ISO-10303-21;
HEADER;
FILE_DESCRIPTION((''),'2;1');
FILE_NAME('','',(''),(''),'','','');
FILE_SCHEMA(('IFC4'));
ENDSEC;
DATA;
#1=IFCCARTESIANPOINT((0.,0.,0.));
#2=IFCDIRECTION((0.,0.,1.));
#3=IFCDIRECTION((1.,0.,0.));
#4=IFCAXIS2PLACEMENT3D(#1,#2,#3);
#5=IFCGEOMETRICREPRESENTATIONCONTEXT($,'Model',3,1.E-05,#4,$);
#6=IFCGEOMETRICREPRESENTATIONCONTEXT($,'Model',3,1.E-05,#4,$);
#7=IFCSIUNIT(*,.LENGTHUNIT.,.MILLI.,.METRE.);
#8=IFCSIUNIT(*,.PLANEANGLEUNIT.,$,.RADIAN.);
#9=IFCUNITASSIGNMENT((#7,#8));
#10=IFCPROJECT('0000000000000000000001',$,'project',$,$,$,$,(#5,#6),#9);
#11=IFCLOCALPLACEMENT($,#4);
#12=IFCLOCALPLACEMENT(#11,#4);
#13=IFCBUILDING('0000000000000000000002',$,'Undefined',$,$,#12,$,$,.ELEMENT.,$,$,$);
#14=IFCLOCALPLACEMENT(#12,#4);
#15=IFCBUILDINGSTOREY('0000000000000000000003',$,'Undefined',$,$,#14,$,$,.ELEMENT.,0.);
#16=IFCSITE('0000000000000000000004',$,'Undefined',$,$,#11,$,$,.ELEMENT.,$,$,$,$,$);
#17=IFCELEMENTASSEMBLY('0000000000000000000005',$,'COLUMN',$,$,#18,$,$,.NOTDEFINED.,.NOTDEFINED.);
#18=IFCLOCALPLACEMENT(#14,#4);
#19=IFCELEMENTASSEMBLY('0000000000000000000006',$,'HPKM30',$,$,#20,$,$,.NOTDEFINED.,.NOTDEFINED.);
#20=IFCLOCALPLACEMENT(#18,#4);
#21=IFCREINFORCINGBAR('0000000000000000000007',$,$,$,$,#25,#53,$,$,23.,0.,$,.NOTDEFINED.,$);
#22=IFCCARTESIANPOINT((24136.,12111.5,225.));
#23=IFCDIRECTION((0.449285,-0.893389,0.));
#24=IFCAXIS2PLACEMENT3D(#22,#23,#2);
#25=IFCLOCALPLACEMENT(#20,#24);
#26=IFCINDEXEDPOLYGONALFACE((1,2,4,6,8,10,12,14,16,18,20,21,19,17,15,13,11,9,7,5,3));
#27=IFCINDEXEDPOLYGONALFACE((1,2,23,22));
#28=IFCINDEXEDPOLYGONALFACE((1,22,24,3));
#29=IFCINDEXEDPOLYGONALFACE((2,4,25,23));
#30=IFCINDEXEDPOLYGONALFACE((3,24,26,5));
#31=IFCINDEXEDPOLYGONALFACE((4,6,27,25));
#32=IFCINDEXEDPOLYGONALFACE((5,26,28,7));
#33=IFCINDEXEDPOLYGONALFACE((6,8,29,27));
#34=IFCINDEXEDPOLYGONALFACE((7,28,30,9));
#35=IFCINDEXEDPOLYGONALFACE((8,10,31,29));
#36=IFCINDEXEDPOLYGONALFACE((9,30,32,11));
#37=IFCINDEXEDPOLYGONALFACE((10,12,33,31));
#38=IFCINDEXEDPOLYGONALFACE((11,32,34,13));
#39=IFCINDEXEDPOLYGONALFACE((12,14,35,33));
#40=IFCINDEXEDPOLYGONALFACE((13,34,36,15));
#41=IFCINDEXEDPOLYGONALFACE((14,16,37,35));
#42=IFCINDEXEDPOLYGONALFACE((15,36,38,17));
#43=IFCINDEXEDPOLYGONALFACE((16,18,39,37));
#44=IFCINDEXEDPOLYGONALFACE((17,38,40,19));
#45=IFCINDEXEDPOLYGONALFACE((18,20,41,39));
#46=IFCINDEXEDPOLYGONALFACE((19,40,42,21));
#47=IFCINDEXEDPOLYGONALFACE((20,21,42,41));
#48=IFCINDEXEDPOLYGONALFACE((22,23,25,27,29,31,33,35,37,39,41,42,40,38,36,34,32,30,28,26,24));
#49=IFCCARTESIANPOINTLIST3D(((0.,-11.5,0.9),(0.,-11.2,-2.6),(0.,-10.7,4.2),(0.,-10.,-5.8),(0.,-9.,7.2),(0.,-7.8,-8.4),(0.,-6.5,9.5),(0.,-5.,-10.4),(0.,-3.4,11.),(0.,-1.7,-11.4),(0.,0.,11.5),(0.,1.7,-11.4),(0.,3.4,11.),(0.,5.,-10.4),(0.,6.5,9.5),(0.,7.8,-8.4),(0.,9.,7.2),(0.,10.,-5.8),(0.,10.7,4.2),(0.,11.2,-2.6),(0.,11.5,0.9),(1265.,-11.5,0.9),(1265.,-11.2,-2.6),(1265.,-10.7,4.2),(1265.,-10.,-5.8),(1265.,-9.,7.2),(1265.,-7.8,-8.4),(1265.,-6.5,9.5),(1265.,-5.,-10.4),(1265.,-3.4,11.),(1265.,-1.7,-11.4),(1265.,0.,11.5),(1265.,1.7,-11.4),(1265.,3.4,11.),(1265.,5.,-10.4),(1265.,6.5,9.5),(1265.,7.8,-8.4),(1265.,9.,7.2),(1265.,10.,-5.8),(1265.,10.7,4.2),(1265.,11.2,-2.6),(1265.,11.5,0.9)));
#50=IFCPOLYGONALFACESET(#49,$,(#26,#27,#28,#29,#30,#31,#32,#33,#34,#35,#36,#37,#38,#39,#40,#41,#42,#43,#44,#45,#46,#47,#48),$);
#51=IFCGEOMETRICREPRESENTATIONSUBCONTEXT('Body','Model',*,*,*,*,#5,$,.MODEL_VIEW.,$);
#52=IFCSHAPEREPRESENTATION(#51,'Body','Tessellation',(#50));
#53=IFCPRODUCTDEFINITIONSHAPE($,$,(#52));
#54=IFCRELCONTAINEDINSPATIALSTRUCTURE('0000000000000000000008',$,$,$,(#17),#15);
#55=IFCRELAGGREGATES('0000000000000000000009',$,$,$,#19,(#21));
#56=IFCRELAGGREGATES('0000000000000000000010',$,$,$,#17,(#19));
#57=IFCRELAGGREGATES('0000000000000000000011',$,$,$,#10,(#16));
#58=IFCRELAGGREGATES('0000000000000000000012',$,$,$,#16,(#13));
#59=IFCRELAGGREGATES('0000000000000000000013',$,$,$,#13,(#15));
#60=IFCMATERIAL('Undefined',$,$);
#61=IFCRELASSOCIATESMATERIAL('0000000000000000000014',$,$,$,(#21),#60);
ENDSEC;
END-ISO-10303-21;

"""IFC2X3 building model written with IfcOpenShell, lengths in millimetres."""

from ifc_helpers import new_model, entity, si_unit, frame, origin_with_axes, place, context, subcontext, project, spatial, source, transform, mapped, material, element, aggregate, save


model = new_model("IFC2X3")

# Units and contexts
model_context_1 = context("Model", 3, precision=1e-05, world=origin_with_axes())
model_context_2 = context("Model", 3, precision=1e-05, world=origin_with_axes())
body_context = subcontext(model_context_1, "Body", "Model", "MODEL_VIEW")
ifc_project = project(units=[si_unit("LENGTHUNIT", "METRE", prefix="MILLI"), si_unit("PLANEANGLEUNIT", "RADIAN")], contexts=[model_context_1, model_context_2])

# Site, building, storey
site_placement = place(None, origin_with_axes())
site = spatial("IfcSite", under=ifc_project, at=site_placement, Name="Undefined", CompositionType="ELEMENT")
building_placement = place(site_placement, origin_with_axes())
building = spatial("IfcBuilding", under=site, at=building_placement, Name="Undefined", CompositionType="ELEMENT")
storey_placement = place(building_placement, origin_with_axes())
storey = spatial("IfcBuildingStorey", under=building, at=storey_placement, Name="Undefined", CompositionType="ELEMENT", Elevation=0.0)

# Element assembly
assembly_1_placement = place(storey_placement, origin_with_axes())
assembly_1 = element("IfcElementAssembly", 1, at=assembly_1_placement, inside=storey, Name="COLUMN", AssemblyPlace="NOTDEFINED", PredefinedType="NOTDEFINED")

# Element assembly
assembly_2_placement = place(assembly_1_placement, origin_with_axes())
assembly_2 = element("IfcElementAssembly", 2, at=assembly_2_placement, Name="HPKM30", AssemblyPlace="NOTDEFINED", PredefinedType="NOTDEFINED")

# Shared definitions
ifc_material_1 = material(Name="Undefined")

# Reinforcing bar
shared_shape_1 = source(origin_with_axes(), body_context, "Body", "AdvancedSweptSolid", [
    entity("IfcSweptDiskSolid", entity("IfcTrimmedCurve", entity("IfcLine", entity("IfcCartesianPoint", [0.0, 0.0, 0.0]), entity("IfcVector", entity("IfcDirection", [1.0, 0.0, 0.0]), 1.0)), [entity("IfcParameterValue", 0.0)], [entity("IfcParameterValue", 1265.0)], True, "PARAMETER"), 11.5, None, 0.0, 1265.0),
])
reinforcing_bar_1_placement = place(assembly_2_placement, frame((24136.0, 12111.5, 225.0), z_axis=(0.449285, -0.893389, 0.0), x_axis=(0.0, 0.0, 1.0)))
reinforcing_bar_1 = element("IfcReinforcingBar", 3, at=reinforcing_bar_1_placement, material=ifc_material_1, BarRole="NOTDEFINED", CrossSectionArea=0.0, NominalDiameter=23.0, context=body_context, shape_type="MappedRepresentation", body=[
    mapped(shared_shape_1, transform((0.0, 0.0, 0.0))),
])
aggregate(assembly_2, [reinforcing_bar_1])
aggregate(assembly_1, [assembly_2])

save(model, "model.ifc")
